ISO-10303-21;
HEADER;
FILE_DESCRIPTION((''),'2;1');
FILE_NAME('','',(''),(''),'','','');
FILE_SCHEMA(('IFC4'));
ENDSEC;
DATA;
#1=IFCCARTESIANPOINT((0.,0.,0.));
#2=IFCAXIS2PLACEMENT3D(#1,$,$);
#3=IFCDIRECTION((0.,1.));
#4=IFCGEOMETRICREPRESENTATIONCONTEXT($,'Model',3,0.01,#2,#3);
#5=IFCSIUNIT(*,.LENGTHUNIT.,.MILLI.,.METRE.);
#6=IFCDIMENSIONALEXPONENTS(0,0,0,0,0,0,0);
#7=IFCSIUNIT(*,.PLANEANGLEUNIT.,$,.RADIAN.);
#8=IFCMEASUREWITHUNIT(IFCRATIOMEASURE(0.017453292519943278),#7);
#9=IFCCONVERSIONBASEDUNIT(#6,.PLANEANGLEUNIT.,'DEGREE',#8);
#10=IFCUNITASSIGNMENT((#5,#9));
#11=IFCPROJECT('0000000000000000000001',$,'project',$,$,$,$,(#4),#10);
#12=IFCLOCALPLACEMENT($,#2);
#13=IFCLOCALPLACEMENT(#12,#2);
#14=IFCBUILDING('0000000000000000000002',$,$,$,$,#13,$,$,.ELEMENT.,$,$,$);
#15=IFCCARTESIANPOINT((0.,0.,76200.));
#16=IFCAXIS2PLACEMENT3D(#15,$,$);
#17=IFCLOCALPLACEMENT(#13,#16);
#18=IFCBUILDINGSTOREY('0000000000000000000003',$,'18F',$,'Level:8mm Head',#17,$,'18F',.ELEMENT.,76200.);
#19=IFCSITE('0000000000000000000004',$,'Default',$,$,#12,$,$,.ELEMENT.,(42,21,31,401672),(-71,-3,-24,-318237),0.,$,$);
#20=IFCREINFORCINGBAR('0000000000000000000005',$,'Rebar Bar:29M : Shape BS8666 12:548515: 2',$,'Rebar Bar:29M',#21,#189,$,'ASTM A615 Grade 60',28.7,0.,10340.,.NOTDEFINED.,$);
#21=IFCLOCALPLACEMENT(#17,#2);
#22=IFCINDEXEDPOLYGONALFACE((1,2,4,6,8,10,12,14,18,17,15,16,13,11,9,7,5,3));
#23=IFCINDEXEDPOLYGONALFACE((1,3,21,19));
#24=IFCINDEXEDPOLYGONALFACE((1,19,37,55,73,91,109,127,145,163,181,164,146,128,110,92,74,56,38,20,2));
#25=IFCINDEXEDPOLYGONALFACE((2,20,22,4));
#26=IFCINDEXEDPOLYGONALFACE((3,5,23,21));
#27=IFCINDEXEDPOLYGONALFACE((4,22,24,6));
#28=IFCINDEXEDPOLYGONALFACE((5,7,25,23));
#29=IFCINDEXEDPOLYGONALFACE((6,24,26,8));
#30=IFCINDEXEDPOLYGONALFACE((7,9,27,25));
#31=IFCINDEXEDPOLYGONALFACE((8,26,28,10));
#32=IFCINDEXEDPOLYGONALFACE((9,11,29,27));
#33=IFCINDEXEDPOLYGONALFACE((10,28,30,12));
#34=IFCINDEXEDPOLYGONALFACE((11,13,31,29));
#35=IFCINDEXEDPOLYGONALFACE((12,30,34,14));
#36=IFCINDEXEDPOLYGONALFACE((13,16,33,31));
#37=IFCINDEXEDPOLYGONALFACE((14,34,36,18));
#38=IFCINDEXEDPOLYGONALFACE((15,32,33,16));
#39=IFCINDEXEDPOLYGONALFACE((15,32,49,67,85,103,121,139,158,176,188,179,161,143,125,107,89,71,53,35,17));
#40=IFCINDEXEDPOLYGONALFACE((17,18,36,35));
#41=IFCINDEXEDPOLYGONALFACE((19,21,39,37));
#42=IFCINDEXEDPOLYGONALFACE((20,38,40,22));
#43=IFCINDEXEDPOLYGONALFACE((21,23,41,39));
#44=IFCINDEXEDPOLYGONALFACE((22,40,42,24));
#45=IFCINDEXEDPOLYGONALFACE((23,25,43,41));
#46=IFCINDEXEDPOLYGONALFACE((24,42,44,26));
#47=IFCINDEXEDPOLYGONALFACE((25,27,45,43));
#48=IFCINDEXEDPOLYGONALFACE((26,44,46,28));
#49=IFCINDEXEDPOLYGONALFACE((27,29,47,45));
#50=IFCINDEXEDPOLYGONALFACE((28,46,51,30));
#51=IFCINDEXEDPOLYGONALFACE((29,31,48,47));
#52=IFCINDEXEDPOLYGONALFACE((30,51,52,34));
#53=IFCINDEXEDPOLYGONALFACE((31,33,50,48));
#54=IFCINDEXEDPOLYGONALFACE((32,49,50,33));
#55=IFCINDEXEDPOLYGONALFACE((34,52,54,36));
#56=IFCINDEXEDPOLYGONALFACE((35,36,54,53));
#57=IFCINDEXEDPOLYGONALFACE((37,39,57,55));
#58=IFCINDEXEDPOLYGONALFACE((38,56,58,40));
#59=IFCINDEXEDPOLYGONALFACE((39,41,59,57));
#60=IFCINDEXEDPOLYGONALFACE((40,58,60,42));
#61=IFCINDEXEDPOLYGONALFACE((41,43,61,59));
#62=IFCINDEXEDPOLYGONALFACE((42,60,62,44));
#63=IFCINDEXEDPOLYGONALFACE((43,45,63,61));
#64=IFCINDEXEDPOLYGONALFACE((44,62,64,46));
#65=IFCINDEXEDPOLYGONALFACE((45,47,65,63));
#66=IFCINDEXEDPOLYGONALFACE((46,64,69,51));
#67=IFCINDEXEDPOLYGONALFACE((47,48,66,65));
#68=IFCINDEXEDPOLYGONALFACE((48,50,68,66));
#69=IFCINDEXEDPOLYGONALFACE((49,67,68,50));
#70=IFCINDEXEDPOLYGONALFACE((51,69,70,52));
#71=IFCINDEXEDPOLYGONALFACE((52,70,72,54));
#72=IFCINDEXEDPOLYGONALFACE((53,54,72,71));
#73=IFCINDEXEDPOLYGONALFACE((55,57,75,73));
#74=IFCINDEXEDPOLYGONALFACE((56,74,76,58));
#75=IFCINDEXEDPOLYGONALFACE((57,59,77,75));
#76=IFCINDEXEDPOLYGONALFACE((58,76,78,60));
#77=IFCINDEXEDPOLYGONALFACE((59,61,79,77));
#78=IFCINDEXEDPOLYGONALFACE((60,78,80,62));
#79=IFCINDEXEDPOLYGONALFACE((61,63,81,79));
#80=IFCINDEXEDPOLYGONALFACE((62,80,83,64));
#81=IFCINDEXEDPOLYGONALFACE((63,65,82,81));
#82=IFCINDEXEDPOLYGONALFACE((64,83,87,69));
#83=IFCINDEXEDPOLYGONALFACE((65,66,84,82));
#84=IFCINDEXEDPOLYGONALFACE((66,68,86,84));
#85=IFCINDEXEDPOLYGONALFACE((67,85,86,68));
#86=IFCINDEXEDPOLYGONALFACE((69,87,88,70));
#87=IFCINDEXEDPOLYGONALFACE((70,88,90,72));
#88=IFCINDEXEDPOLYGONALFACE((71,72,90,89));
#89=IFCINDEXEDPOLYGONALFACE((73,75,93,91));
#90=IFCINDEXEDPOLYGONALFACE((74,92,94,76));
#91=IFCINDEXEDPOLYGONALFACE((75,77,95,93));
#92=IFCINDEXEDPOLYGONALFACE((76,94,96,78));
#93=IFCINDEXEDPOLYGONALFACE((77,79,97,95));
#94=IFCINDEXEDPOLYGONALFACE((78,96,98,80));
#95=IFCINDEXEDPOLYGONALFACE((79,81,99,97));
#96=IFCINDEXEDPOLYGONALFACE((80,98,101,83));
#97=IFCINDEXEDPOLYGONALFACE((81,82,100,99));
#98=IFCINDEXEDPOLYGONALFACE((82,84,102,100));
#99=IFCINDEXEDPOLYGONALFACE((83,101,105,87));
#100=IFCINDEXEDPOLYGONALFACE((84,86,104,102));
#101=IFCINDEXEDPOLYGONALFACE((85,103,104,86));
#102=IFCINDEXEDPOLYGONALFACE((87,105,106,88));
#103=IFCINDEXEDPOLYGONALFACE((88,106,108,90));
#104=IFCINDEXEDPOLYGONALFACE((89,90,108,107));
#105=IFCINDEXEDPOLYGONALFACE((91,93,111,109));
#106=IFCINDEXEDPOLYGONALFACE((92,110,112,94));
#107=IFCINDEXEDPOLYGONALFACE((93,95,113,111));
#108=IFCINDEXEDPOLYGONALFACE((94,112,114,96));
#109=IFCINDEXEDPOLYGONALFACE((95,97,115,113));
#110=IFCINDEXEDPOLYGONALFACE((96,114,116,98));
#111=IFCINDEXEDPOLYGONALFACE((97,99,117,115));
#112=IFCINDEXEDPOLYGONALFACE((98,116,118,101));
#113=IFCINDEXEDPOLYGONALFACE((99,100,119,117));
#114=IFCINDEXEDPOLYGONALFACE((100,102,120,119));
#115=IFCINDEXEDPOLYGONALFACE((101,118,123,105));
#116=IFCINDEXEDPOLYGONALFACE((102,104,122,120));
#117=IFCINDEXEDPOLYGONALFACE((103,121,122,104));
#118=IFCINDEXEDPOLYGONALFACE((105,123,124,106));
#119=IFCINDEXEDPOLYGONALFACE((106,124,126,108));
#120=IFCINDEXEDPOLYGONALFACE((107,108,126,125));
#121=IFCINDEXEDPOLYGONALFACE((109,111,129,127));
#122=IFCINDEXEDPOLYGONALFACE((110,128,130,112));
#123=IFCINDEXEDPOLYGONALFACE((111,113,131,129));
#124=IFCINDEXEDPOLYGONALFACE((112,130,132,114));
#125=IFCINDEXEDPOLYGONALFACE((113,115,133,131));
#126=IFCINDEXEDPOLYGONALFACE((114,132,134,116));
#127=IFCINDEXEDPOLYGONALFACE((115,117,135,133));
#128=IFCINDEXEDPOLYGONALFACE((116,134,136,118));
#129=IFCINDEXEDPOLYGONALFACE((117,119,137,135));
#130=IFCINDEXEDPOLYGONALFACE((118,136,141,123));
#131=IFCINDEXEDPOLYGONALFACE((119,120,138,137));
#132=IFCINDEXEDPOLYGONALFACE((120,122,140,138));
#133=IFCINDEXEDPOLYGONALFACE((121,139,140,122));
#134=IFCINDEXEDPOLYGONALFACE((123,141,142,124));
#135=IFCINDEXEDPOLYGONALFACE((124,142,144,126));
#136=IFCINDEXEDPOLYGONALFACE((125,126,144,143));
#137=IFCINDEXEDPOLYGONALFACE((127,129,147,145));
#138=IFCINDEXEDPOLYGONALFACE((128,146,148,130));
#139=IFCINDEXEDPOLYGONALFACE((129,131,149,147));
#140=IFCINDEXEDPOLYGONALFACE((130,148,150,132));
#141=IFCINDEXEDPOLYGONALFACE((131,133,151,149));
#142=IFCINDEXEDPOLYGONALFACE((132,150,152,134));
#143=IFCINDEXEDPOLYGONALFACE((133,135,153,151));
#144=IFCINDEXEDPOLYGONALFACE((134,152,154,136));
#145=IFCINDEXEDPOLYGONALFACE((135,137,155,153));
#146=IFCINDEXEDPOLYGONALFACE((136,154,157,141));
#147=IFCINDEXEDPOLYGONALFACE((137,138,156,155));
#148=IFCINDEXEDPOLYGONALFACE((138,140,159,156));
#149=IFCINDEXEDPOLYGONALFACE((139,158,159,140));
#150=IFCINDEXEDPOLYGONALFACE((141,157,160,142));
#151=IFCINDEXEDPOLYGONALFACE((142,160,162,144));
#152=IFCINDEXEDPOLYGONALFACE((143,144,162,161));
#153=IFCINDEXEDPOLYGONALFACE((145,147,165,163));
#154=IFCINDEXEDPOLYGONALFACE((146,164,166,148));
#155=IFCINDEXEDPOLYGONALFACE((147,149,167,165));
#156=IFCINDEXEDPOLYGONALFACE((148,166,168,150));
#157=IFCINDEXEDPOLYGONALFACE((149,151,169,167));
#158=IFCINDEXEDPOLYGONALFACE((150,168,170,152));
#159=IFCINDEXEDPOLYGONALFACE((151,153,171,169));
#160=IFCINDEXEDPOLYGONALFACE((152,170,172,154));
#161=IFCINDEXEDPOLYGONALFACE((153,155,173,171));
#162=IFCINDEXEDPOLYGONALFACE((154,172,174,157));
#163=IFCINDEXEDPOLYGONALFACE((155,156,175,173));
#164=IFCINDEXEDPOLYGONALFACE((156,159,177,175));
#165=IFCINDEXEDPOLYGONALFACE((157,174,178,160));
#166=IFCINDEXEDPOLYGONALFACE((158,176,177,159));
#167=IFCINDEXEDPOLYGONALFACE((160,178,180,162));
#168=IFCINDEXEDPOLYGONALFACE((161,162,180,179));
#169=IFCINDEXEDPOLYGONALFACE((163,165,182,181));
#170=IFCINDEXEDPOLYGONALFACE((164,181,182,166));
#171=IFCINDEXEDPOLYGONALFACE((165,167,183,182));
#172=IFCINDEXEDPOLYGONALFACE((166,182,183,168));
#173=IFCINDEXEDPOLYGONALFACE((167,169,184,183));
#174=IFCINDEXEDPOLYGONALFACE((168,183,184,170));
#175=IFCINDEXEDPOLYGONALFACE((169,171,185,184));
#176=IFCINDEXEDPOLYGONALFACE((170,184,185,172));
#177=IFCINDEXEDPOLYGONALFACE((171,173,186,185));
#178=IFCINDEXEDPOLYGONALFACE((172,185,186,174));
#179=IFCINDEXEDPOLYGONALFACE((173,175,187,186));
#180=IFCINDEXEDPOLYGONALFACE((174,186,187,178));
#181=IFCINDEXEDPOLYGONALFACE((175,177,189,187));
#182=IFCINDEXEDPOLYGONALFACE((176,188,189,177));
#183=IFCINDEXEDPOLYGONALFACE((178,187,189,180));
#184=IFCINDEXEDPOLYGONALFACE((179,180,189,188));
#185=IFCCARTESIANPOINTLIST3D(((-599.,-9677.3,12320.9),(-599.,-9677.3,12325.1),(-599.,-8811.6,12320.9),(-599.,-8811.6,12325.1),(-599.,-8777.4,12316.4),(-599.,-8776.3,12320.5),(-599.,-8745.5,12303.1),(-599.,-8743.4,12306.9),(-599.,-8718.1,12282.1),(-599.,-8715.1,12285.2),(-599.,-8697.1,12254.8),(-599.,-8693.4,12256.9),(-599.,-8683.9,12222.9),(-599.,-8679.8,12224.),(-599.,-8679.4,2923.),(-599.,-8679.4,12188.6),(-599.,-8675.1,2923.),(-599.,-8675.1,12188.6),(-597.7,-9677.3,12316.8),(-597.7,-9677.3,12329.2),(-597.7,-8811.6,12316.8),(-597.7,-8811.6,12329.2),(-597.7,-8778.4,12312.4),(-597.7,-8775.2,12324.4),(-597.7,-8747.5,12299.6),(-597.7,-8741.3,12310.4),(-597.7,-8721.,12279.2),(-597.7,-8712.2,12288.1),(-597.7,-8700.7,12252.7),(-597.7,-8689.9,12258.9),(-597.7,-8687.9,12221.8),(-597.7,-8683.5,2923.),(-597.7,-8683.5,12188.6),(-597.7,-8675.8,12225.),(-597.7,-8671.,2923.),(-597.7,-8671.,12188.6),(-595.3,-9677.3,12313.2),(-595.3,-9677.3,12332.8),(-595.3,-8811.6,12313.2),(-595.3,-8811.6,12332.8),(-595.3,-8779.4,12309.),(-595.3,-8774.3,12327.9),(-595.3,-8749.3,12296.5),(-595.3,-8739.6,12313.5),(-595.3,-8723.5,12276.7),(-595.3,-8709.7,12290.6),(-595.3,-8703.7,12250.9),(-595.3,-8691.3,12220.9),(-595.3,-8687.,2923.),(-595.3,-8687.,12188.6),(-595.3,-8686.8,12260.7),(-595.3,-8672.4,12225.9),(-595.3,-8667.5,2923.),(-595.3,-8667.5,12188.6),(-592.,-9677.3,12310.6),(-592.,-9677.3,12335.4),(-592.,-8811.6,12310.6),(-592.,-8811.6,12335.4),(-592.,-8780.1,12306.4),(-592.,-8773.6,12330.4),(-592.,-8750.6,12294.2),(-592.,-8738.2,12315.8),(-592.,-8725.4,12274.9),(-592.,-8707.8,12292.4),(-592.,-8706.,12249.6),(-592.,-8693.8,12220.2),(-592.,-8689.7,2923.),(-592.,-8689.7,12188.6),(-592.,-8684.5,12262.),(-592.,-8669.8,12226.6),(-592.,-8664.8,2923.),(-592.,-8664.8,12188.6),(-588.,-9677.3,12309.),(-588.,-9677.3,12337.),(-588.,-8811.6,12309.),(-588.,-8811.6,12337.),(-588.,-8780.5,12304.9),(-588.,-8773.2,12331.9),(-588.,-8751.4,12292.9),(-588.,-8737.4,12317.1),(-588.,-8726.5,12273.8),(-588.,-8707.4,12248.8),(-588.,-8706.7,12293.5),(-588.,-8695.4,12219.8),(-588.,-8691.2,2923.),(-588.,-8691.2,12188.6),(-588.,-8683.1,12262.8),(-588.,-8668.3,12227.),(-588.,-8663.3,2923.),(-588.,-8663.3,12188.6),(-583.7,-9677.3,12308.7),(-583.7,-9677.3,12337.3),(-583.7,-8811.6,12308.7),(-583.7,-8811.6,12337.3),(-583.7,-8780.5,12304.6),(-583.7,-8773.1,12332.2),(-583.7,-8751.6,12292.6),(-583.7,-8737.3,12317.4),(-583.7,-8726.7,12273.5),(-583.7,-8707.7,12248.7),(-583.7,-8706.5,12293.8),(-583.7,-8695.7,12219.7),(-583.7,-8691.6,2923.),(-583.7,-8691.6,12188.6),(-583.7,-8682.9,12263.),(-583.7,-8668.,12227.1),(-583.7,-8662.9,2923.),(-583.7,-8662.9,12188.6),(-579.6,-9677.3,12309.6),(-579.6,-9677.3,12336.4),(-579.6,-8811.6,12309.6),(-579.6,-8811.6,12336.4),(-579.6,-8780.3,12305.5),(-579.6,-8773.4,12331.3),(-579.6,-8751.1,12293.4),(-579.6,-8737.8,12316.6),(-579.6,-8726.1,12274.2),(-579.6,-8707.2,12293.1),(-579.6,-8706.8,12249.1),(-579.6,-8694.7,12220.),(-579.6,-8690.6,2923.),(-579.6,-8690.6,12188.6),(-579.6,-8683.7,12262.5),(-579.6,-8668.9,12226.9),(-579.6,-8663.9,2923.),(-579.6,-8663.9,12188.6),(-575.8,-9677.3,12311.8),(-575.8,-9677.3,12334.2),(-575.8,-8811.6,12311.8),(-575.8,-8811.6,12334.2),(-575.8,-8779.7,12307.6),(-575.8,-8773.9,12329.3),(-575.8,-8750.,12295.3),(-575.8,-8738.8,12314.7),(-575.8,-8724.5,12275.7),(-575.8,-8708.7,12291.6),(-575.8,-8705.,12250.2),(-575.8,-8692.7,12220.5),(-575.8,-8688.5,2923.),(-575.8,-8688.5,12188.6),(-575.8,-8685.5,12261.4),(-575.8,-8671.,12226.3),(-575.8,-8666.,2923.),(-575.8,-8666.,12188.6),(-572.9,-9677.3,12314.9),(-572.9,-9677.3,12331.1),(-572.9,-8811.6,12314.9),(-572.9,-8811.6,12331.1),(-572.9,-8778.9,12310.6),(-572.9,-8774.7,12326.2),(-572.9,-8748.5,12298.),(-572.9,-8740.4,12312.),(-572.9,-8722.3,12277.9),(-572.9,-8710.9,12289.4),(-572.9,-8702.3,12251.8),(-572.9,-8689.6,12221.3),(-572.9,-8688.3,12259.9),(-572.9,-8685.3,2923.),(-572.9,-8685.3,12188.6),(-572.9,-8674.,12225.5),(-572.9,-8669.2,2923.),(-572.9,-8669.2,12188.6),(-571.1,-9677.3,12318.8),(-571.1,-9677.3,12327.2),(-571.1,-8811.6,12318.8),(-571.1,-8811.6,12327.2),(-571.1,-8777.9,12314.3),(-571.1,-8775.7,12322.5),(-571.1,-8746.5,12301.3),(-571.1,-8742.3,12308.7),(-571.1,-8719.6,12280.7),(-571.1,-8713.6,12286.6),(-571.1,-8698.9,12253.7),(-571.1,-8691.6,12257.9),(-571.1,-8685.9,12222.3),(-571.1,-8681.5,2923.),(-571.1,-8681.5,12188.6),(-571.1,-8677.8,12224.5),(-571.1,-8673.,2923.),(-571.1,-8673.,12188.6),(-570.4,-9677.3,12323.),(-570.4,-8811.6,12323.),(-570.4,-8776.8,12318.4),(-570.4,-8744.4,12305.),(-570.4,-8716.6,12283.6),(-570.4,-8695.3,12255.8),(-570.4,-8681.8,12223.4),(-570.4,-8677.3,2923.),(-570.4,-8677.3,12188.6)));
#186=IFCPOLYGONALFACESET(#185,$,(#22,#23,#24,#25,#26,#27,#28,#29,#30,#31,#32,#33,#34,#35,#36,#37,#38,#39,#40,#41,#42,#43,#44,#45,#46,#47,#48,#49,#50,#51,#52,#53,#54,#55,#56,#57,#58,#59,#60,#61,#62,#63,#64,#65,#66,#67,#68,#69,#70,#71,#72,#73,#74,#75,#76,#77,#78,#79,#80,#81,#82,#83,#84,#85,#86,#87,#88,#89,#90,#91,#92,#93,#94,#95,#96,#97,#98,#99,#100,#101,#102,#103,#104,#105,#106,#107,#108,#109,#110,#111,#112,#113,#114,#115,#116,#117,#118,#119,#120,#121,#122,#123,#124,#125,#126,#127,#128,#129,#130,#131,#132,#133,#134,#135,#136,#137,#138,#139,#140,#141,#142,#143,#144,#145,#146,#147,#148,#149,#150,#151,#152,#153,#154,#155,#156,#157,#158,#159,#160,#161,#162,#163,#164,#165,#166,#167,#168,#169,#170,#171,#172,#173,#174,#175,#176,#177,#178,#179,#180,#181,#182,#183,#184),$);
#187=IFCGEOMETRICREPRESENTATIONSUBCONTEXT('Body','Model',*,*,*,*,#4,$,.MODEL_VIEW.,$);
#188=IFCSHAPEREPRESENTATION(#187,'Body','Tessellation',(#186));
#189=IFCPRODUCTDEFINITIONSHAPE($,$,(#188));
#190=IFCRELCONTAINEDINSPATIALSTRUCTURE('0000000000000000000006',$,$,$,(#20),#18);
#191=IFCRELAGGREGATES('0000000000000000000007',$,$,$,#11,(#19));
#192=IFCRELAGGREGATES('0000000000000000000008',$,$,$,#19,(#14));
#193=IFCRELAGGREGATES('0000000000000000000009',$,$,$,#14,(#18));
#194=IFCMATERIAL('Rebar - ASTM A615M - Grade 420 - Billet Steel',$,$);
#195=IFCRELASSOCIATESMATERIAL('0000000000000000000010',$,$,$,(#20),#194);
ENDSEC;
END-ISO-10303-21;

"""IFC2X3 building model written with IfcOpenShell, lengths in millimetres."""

from ifc_helpers import new_model, entity, si_unit, converted_unit, direction, frame, origin, place, context, subcontext, project, spatial, material, element, save


model = new_model("IFC2X3")

# Units and contexts
model_context = context("Model", 3, precision=0.01, world=origin(), true_north=direction((0.0, 1.0)))
body_context = subcontext(model_context, "Body", "Model", "MODEL_VIEW")
ifc_project = project(units=[si_unit("LENGTHUNIT", "METRE", prefix="MILLI"), converted_unit("PLANEANGLEUNIT", "DEGREE", entity("IfcRatioMeasure", 0.017453292519943278), si_unit("PLANEANGLEUNIT", "RADIAN"), dimensions=[0, 0, 0, 0, 0, 0, 0])], contexts=[model_context])

# Site, building, storey
site_placement = place(None, origin())
site = spatial("IfcSite", under=ifc_project, at=site_placement, Name="Default", CompositionType="ELEMENT", RefLatitude=(42, 21, 31, 401672), RefLongitude=(-71, -3, -24, -318237), RefElevation=0.0)
building_placement = place(site_placement, origin())
building = spatial("IfcBuilding", under=site, at=building_placement, CompositionType="ELEMENT")
storey_placement = place(building_placement, frame((0.0, 0.0, 76200.0)))
storey = spatial("IfcBuildingStorey", under=building, at=storey_placement, Name="18F", ObjectType="Level:8mm Head", LongName="18F", CompositionType="ELEMENT", Elevation=76200.0)

# Reinforcing bar
ifc_material_1 = material(Name="Rebar - ASTM A615M - Grade 420 - Billet Steel")
reinforcing_bar_1_placement = place(storey_placement, origin())
element("IfcReinforcingBar", 1, at=reinforcing_bar_1_placement, inside=storey, material=ifc_material_1, Name="Rebar Bar:29M : Shape BS8666 12:548515: 2", SteelGrade="ASTM A615 Grade 60", ObjectType="Rebar Bar:29M", BarLength=10340.0, BarRole="NOTDEFINED", CrossSectionArea=0.0, NominalDiameter=28.7, context=body_context, shape_type="AdvancedSweptSolid", body=[
    entity("IfcSweptDiskSolid", entity("IfcCompositeCurve", [entity("IfcCompositeCurveSegment", "CONTINUOUS", True, entity("IfcPolyline", [entity("IfcCartesianPoint", [-584.8, -8677.3, 2923.0]), entity("IfcCartesianPoint", [-584.8, -8677.3, 12188.6])])), entity("IfcCompositeCurveSegment", "CONTINUOUS", True, entity("IfcTrimmedCurve", entity("IfcCircle", entity("IfcAxis2Placement3D", entity("IfcCartesianPoint", [-584.8, -8811.6, 12188.6]), entity("IfcDirection", [1.0, 0.0, 0.0]), entity("IfcDirection", [0.0, 0.0, 1.0])), 134.3), [entity("IfcParameterValue", 270.0)], [entity("IfcParameterValue", 360.0)], True, "PARAMETER")), entity("IfcCompositeCurveSegment", "CONTINUOUS", True, entity("IfcPolyline", [entity("IfcCartesianPoint", [-584.8, -8811.6, 12323.0]), entity("IfcCartesianPoint", [-584.8, -9677.3, 12323.0])]))], False), 14.3, None, 0.0, 92.0),
])

save(model, "model.ifc")
